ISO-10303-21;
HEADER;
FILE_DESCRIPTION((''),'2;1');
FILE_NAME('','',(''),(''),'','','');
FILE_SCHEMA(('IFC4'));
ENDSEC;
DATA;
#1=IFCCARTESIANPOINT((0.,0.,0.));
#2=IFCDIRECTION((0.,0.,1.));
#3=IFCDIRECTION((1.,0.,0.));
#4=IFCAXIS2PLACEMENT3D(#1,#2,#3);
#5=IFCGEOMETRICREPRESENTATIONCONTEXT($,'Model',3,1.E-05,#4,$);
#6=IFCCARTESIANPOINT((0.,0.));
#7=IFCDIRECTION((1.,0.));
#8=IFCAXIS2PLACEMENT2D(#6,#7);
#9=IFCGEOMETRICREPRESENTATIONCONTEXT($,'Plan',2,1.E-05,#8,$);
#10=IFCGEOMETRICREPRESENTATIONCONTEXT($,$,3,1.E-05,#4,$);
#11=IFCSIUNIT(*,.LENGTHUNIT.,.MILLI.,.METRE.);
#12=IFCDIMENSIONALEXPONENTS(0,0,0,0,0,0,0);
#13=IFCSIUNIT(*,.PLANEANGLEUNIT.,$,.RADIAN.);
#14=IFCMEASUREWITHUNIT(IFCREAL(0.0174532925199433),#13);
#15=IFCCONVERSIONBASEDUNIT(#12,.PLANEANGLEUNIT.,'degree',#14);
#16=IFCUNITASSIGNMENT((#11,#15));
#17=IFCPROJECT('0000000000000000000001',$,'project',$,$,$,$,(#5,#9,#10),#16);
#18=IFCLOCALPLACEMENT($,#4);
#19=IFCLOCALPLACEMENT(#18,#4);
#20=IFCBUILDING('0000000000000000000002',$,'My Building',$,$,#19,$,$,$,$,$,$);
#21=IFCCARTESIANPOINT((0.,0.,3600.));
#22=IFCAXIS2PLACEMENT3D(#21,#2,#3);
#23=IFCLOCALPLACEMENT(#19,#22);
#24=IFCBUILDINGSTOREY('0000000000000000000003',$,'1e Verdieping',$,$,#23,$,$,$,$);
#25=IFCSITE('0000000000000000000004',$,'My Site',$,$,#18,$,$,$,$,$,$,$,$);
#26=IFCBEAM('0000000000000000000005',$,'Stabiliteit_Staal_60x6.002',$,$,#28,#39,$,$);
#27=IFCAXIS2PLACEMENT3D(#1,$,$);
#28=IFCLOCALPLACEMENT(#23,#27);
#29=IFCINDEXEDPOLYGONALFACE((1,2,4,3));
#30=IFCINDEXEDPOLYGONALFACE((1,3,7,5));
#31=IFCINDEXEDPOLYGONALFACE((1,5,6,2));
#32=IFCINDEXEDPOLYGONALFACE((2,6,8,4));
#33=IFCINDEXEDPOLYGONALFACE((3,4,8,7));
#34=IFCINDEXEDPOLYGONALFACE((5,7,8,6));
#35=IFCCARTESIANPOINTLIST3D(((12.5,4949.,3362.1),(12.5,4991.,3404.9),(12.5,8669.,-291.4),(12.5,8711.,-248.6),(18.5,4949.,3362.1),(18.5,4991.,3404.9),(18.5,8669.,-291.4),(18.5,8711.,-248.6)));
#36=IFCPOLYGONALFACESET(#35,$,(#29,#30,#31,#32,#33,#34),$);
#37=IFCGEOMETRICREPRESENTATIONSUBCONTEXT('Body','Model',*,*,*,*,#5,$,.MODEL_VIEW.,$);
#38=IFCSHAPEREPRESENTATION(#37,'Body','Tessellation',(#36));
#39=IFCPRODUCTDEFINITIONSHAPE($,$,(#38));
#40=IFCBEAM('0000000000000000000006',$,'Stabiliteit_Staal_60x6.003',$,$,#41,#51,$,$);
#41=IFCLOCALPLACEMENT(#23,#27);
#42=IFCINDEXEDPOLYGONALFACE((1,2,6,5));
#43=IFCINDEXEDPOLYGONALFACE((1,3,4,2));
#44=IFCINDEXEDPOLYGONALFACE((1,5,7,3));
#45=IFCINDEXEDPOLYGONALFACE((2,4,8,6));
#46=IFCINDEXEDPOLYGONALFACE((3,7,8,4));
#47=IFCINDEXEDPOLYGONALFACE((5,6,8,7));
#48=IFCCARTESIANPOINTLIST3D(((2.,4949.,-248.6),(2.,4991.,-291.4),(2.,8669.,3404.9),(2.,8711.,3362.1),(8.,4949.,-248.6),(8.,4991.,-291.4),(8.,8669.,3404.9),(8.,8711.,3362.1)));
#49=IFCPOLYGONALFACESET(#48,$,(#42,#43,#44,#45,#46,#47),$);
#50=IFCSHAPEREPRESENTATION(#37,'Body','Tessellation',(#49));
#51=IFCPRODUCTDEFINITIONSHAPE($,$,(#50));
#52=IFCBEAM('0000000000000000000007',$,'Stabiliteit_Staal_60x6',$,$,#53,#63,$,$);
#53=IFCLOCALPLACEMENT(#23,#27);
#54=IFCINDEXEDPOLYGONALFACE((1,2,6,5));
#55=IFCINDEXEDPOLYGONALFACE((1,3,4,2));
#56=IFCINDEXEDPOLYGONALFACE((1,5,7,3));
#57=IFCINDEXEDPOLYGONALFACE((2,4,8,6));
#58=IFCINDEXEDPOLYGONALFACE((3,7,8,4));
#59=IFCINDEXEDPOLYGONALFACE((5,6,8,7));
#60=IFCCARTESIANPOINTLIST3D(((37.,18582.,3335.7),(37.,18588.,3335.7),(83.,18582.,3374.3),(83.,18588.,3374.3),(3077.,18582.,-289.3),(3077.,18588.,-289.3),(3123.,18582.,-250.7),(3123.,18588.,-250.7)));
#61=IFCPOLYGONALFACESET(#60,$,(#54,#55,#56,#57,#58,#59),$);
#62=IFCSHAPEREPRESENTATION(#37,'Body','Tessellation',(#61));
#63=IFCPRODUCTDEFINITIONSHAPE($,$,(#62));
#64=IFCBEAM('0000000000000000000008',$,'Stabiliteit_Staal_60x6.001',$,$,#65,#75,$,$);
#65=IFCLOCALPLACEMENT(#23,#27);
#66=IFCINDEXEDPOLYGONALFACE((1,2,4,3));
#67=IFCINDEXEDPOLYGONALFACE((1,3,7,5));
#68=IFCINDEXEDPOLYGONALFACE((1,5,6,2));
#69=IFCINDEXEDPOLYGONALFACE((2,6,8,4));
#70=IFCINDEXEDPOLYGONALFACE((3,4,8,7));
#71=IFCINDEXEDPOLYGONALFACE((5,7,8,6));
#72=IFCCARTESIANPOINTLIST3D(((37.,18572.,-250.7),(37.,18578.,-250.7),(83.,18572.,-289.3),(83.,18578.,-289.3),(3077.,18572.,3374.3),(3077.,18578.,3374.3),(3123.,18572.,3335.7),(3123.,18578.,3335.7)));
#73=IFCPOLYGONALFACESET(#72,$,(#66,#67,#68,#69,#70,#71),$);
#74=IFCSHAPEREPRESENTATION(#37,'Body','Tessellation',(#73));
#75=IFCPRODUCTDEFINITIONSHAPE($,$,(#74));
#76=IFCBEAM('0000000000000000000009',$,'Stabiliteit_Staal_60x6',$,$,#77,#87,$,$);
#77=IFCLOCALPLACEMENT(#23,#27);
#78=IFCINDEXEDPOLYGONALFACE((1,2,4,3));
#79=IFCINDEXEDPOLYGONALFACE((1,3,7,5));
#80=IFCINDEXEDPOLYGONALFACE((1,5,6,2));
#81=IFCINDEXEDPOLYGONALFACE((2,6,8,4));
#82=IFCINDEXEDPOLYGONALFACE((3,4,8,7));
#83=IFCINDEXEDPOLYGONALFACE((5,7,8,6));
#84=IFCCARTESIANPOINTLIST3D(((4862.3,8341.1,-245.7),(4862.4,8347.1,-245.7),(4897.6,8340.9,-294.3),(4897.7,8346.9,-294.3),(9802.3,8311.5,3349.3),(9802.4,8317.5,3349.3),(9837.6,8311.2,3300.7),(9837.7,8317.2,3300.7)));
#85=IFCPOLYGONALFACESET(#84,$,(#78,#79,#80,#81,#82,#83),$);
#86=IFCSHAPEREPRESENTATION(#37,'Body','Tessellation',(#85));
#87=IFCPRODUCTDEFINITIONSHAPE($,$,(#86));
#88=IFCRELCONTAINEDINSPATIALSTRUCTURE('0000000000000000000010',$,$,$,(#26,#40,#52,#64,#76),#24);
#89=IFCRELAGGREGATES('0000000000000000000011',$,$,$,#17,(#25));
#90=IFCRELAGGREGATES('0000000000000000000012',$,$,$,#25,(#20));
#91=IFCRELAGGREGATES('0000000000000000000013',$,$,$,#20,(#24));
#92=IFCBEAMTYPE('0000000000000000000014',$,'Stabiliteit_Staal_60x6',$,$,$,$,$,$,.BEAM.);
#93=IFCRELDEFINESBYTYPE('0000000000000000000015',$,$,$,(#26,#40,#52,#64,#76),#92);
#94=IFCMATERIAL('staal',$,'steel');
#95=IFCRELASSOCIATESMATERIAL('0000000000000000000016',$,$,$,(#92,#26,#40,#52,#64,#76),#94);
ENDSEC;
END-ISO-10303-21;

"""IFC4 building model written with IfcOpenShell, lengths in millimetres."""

from ifc_helpers import new_model, entity, si_unit, converted_unit, frame, origin_with_axes, origin_2d_with_axis, place, context, subcontext, project, spatial, rectangle, extrude, material, material_profile, profile_set, profile_usage, type_object, element, save


model = new_model("IFC4")

# Units and contexts
model_context = context("Model", 3, precision=1e-05, world=origin_with_axes())
plan_context = context("Plan", 2, precision=1e-05, world=origin_2d_with_axis())
context_of_model = context(None, 3, precision=1e-05, world=origin_with_axes())
body_context = subcontext(model_context, "Body", "Model", "MODEL_VIEW")
ifc_project = project(units=[si_unit("LENGTHUNIT", "METRE", prefix="MILLI"), converted_unit("PLANEANGLEUNIT", "degree", entity("IfcReal", 0.0174532925199433), si_unit("PLANEANGLEUNIT", "RADIAN"), dimensions=[0, 0, 0, 0, 0, 0, 0])], contexts=[model_context, plan_context, context_of_model])

# Site, building, storey
site_placement = place(None, origin_with_axes())
site = spatial("IfcSite", under=ifc_project, at=site_placement, Name="My Site")
building_placement = place(site_placement, origin_with_axes())
building = spatial("IfcBuilding", under=site, at=building_placement, Name="My Building")
storey_placement = place(building_placement, frame((0.0, 0.0, 3600.0), z_axis=(0.0, 0.0, 1.0), x_axis=(1.0, 0.0, 0.0)))
storey = spatial("IfcBuildingStorey", under=building, at=storey_placement, Name="1e Verdieping")

# Shared definitions
ifc_material = material(Name="staal", Category="steel")

# Beams
ifc_material_profile_1 = material_profile(ifc_material, rectangle(XDim=6.0, YDim=60.0, kind="CURVE"))
ifc_profile_set_1 = profile_set([ifc_material_profile_1])
beam_type_1 = type_object("IfcBeamType", Name="Stabiliteit_Staal_60x6", PredefinedType="BEAM", material=ifc_profile_set_1)
ifc_profile_usage_1 = profile_usage(ifc_profile_set_1)
beam_1_placement = place(storey_placement, frame((15.5, 8690.0, -270.0), z_axis=(0.0, -0.713455, 0.700701), x_axis=(1.0, 0.0, 0.0)))
element("IfcBeam", 1, at=beam_1_placement, inside=storey, type_object=beam_type_1, material=ifc_profile_usage_1, Name="Stabiliteit_Staal_60x6.002", context=body_context, shape_type="SweptSolid", body=[
    extrude(rectangle(XDim=6.0, YDim=60.0, kind="CURVE"), origin_with_axes(), (0.0, 0.0, 1.0), 5214.1),
])
ifc_profile_usage_2 = profile_usage(ifc_profile_set_1)
beam_2_placement = place(storey_placement, frame((5.0, 4970.0, -270.0), z_axis=(0.0, 0.713455, 0.700701), x_axis=(-1.0, 0.0, 0.0)))
element("IfcBeam", 2, at=beam_2_placement, inside=storey, type_object=beam_type_1, material=ifc_profile_usage_2, Name="Stabiliteit_Staal_60x6.003", context=body_context, shape_type="SweptSolid", body=[
    extrude(rectangle(XDim=6.0, YDim=60.0, kind="CURVE"), origin_with_axes(), (0.0, 0.0, 1.0), 5214.1),
])
ifc_profile_usage_3 = profile_usage(ifc_profile_set_1)
beam_3_placement = place(storey_placement, frame((3100.0, 18585.0, -270.0), z_axis=(-0.642572, 0.0, 0.766225), x_axis=(0.0, -1.0, 0.0)))
element("IfcBeam", 3, at=beam_3_placement, inside=storey, type_object=beam_type_1, material=ifc_profile_usage_3, Name="Stabiliteit_Staal_60x6", context=body_context, shape_type="SweptSolid", body=[
    extrude(rectangle(XDim=6.0, YDim=60.0, kind="CURVE"), origin_with_axes(), (0.0, 0.0, 1.0), 4731.0),
])
ifc_profile_usage_4 = profile_usage(ifc_profile_set_1)
beam_4_placement = place(storey_placement, frame((60.0, 18575.0, -270.0), z_axis=(0.642573, 0.0, 0.766225), x_axis=(0.0, 1.0, 0.0)))
element("IfcBeam", 4, at=beam_4_placement, inside=storey, type_object=beam_type_1, material=ifc_profile_usage_4, Name="Stabiliteit_Staal_60x6.001", context=body_context, shape_type="SweptSolid", body=[
    extrude(rectangle(XDim=6.0, YDim=60.0, kind="CURVE"), origin_with_axes(), (0.0, 0.0, 1.0), 4731.0),
])
ifc_profile_usage_5 = profile_usage(ifc_profile_set_1)
beam_5_placement = place(storey_placement, frame((4880.0, 8344.0, -270.0), z_axis=(0.80855, -0.004859, 0.588408), x_axis=(0.006009, 0.999982, 0.0)))
element("IfcBeam", 5, at=beam_5_placement, inside=storey, type_object=beam_type_1, material=ifc_profile_usage_5, Name="Stabiliteit_Staal_60x6", context=body_context, shape_type="SweptSolid", body=[
    extrude(rectangle(XDim=6.0, YDim=60.0, kind="CURVE"), origin_with_axes(), (0.0, 0.0, 1.0), 6109.7),
])

save(model, "model.ifc")
